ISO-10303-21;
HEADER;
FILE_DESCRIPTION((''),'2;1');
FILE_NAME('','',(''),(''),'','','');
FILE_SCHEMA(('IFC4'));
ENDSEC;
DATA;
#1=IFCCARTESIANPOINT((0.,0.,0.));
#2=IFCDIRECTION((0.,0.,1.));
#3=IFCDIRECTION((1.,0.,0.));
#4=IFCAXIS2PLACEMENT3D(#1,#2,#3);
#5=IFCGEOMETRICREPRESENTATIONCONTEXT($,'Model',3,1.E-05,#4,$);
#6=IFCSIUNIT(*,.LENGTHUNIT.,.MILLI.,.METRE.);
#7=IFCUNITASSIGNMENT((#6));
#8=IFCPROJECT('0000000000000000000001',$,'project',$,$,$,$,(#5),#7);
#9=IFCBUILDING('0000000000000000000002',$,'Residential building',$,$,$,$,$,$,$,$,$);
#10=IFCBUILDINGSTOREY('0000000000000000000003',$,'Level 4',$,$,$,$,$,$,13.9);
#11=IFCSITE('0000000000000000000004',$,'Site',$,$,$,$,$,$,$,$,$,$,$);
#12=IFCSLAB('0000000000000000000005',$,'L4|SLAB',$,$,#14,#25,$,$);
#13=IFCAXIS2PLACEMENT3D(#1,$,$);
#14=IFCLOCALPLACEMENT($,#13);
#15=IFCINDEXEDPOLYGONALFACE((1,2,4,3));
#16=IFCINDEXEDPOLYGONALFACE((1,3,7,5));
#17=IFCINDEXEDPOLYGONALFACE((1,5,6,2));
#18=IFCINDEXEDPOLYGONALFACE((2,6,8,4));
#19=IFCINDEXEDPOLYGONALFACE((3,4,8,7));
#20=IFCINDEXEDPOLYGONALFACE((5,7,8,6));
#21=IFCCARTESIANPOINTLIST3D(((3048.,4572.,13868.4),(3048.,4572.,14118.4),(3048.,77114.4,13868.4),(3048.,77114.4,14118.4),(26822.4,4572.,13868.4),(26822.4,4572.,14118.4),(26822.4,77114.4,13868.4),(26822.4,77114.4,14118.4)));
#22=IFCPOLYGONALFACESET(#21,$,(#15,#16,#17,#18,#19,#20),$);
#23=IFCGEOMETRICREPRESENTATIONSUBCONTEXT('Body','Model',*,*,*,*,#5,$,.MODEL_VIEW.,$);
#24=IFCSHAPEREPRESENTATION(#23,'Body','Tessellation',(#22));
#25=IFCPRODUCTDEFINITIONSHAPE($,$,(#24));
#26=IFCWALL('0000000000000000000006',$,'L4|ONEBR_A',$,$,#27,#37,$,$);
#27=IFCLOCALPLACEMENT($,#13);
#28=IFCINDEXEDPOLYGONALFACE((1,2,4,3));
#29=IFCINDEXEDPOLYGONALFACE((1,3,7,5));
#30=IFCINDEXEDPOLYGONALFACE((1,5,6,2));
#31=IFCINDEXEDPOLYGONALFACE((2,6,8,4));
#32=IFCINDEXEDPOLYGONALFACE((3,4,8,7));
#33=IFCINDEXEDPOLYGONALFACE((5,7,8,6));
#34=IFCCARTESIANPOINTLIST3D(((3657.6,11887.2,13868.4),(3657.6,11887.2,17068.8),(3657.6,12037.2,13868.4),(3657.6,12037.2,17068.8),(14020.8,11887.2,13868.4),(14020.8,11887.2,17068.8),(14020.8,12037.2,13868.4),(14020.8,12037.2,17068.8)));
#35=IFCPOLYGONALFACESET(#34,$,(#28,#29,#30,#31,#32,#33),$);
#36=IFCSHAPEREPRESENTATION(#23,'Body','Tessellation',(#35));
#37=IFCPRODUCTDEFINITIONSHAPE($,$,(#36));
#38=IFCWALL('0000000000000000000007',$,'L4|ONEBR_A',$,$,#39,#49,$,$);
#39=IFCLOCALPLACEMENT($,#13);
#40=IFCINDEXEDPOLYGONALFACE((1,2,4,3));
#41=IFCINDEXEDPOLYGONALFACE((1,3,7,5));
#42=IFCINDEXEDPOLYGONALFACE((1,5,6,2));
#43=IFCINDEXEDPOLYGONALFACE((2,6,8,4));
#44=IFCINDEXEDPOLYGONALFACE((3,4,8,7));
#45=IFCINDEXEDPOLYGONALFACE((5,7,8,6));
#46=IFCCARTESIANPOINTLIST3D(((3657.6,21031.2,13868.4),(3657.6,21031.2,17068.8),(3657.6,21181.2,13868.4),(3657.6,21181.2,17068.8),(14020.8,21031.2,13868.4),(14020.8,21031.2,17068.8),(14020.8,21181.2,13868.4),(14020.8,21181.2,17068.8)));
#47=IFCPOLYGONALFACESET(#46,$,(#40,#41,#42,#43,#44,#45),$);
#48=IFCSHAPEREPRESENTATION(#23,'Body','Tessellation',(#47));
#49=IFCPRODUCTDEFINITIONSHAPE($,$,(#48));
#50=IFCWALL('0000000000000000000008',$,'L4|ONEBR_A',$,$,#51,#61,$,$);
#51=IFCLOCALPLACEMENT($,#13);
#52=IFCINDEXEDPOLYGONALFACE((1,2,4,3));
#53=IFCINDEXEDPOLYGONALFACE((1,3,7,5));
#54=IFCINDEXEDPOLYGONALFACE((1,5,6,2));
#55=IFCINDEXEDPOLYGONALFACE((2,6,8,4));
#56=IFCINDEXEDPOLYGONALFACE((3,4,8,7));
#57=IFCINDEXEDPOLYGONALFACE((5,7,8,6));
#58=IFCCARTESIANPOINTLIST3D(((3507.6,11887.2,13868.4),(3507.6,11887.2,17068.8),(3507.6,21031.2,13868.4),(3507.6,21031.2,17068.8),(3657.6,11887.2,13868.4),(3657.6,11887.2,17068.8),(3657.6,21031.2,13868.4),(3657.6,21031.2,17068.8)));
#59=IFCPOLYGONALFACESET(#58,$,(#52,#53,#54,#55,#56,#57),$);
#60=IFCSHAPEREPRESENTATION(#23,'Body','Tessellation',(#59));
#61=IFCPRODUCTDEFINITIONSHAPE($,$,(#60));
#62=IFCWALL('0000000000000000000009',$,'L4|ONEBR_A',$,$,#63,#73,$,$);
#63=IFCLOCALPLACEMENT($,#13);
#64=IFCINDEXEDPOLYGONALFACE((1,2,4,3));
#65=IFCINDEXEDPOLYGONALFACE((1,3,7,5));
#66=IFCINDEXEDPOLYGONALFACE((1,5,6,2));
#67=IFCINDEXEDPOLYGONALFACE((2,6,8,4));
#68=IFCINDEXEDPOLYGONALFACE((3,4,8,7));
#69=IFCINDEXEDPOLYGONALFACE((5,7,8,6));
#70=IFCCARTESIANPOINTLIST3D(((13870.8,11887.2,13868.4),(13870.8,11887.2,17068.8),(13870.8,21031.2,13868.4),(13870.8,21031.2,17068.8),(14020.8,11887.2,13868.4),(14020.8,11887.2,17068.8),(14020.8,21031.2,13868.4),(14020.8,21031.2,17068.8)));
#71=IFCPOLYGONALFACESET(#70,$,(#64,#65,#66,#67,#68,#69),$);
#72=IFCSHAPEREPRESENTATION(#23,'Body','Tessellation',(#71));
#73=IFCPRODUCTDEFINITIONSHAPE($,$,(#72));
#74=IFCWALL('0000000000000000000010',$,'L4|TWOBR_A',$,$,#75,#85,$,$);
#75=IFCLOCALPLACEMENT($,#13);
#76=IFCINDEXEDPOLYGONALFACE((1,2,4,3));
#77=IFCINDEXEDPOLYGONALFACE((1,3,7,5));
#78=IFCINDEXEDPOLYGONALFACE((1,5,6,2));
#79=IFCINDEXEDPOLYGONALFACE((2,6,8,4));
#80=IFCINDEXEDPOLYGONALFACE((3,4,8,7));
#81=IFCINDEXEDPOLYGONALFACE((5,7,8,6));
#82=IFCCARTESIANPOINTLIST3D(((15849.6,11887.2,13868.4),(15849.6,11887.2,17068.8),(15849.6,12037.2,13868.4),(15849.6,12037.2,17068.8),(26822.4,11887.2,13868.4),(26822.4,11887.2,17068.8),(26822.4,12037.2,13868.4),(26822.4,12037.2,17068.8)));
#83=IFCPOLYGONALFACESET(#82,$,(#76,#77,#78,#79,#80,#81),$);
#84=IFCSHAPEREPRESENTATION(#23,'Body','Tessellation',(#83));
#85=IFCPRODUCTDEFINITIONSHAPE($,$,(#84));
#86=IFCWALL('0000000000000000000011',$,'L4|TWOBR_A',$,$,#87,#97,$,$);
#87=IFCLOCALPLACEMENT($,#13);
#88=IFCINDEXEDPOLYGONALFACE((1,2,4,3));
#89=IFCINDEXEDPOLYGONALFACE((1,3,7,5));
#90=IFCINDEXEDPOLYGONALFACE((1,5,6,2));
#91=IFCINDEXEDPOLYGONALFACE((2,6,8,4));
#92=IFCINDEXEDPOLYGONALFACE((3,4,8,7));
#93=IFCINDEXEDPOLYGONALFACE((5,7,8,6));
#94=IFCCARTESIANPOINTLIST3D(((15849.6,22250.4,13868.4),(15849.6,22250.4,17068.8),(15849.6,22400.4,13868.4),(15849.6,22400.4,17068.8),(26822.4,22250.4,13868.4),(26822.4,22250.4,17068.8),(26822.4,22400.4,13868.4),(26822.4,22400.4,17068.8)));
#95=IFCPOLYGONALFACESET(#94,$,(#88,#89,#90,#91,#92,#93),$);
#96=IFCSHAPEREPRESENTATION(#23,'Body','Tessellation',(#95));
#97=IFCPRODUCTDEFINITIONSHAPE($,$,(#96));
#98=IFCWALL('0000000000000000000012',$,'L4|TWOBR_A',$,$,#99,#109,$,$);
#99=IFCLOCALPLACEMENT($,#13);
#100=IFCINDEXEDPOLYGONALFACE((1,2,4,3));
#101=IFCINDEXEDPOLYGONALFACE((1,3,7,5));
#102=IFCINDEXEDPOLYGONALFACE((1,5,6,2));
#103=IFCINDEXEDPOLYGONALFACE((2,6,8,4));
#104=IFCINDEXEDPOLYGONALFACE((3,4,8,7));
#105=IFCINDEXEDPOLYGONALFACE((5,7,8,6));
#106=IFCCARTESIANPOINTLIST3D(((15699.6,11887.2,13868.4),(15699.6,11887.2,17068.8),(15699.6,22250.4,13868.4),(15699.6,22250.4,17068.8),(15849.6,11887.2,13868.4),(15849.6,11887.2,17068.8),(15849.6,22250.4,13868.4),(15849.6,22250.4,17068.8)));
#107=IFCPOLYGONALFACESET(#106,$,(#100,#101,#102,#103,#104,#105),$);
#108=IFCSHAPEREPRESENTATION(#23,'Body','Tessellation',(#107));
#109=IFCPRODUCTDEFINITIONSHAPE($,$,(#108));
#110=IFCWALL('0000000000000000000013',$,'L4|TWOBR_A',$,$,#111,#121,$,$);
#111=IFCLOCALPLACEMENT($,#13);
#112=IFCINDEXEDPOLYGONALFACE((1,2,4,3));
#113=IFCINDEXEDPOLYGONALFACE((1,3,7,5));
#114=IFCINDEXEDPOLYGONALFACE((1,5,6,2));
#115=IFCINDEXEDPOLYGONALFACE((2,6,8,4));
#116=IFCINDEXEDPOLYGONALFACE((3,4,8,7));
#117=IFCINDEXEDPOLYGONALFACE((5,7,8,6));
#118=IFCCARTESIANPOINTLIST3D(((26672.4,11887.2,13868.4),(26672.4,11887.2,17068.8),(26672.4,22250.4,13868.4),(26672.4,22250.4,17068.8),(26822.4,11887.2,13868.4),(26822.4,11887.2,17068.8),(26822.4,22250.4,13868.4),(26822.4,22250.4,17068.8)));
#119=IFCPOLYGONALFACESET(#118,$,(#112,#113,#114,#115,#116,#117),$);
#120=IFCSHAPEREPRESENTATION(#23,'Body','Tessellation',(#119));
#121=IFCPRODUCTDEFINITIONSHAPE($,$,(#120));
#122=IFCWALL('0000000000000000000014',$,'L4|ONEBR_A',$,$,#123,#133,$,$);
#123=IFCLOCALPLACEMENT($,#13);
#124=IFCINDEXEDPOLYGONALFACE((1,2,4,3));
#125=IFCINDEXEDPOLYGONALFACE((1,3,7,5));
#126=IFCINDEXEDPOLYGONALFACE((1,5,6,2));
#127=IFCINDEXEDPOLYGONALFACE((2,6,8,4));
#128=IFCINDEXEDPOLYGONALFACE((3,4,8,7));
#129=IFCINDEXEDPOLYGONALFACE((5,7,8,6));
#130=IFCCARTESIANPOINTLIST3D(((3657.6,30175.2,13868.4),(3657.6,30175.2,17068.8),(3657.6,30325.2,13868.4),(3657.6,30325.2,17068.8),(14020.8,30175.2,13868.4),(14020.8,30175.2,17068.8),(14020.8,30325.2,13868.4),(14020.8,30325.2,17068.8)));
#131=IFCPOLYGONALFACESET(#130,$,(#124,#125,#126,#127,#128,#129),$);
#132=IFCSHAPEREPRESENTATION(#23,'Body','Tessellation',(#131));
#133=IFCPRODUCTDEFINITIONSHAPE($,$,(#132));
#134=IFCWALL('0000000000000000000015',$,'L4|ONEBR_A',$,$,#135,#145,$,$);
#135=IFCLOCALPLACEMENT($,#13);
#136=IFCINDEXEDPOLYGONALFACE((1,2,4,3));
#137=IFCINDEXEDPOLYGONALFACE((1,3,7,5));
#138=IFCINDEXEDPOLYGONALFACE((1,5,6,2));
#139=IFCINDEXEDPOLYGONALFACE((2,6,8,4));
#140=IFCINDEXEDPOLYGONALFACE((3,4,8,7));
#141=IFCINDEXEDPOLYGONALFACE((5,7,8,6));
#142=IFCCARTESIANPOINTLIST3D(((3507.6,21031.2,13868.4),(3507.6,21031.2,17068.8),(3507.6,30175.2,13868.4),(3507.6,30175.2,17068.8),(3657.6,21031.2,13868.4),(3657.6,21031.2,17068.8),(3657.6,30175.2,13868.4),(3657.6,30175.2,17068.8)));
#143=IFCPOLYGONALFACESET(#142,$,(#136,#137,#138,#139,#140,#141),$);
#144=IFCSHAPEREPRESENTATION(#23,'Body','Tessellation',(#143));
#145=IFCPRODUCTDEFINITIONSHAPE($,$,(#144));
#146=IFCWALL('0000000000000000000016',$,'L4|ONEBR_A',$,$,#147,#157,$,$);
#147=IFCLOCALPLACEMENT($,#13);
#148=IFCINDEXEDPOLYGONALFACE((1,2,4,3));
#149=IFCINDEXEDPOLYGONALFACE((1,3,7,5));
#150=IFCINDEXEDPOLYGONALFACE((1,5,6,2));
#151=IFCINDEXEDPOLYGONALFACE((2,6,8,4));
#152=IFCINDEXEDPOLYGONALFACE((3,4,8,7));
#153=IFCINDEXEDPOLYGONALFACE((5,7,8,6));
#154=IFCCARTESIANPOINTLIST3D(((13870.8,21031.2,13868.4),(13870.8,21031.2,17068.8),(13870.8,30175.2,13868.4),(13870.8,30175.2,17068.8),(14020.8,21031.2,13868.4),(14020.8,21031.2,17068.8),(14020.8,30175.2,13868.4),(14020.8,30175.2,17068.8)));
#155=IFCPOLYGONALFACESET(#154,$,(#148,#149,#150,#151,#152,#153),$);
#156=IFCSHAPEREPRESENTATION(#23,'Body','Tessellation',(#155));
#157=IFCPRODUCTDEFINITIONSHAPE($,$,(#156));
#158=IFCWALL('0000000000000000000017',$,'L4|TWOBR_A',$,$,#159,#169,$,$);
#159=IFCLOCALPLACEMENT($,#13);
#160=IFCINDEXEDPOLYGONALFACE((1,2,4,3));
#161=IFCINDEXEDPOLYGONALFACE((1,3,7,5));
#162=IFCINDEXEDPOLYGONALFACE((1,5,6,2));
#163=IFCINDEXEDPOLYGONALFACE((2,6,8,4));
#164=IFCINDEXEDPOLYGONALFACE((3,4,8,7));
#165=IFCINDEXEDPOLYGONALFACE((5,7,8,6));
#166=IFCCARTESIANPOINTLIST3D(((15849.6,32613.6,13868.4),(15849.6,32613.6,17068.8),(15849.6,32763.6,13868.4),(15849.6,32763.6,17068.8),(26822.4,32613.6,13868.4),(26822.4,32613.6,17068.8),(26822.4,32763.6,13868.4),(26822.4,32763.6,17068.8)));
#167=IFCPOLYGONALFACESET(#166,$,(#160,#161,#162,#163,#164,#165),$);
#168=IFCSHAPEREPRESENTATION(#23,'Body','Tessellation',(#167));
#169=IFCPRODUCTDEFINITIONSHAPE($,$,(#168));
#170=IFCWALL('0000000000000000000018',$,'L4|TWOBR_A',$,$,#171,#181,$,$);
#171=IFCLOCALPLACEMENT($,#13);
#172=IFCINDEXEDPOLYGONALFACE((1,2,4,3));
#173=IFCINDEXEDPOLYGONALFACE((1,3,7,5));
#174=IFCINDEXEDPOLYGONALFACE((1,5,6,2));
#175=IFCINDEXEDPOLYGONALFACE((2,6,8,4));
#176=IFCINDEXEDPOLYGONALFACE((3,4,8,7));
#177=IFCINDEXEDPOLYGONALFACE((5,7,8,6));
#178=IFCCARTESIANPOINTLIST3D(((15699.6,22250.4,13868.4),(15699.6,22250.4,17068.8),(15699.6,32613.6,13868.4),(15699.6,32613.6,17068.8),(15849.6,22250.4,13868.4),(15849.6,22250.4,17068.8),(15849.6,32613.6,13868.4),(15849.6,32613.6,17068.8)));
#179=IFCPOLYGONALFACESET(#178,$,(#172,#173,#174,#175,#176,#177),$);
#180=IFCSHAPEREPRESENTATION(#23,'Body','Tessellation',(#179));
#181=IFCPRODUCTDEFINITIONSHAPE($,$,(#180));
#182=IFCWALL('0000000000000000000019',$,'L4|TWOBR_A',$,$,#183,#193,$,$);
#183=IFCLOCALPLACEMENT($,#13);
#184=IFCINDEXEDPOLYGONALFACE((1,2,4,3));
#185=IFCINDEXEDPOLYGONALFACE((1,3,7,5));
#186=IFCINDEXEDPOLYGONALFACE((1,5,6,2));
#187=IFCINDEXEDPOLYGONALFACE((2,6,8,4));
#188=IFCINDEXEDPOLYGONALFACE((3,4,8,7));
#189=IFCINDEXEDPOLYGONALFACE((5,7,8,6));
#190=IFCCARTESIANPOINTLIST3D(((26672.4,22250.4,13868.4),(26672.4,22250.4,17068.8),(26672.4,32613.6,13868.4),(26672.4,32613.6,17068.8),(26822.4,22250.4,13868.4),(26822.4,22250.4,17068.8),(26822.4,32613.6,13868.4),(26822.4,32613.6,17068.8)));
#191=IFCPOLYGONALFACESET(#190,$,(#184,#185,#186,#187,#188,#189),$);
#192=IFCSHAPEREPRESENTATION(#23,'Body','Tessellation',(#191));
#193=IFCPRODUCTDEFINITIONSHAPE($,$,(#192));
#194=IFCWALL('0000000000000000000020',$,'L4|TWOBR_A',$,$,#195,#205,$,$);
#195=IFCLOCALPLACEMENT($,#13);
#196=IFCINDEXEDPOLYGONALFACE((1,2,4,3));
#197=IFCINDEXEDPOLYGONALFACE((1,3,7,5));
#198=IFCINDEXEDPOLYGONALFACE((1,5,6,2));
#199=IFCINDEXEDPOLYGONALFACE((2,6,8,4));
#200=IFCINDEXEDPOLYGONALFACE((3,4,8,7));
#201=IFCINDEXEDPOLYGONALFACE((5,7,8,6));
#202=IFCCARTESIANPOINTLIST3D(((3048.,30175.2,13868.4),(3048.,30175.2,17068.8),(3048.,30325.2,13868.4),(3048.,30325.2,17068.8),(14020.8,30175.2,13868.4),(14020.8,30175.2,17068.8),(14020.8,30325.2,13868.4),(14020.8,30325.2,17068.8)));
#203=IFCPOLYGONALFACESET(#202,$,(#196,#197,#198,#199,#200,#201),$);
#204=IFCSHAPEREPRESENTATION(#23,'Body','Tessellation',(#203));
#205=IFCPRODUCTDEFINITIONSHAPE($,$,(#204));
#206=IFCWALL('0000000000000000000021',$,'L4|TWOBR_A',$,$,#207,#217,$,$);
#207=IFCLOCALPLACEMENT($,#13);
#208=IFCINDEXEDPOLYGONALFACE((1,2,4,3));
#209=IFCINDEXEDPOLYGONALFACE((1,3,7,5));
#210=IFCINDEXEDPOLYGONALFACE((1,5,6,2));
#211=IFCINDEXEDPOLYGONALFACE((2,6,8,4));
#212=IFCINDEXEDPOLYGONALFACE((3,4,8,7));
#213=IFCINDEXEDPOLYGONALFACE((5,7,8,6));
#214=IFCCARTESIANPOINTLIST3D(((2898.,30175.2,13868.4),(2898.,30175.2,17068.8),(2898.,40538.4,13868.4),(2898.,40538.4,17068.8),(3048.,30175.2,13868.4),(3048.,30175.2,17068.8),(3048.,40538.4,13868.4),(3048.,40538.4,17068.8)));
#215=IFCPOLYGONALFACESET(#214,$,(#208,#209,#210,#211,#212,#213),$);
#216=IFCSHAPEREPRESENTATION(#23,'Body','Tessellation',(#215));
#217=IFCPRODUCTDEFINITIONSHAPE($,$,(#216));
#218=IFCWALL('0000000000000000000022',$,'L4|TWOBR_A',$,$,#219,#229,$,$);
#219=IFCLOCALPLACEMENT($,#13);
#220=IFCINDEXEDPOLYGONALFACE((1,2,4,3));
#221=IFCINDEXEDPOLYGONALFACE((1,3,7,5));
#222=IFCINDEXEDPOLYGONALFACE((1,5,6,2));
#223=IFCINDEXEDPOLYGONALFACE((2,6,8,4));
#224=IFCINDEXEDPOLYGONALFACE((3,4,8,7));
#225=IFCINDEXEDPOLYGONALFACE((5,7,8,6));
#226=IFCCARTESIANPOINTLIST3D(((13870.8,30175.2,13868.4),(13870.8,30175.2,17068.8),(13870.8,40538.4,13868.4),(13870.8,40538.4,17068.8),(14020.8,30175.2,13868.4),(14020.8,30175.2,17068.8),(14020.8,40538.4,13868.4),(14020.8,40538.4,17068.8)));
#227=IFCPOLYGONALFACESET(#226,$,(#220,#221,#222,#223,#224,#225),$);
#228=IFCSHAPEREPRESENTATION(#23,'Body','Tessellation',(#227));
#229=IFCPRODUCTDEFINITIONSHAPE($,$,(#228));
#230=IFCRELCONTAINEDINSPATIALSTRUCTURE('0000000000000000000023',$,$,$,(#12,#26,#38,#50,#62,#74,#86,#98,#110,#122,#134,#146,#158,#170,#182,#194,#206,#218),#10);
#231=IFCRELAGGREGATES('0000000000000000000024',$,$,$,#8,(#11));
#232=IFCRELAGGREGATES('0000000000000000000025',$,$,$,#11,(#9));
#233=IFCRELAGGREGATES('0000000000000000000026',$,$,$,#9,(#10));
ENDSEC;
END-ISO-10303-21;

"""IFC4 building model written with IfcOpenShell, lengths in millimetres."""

from ifc_helpers import new_model, si_unit, frame, origin_with_axes, place, context, subcontext, project, spatial, indexed_curve, outline, extrude, element, save


model = new_model("IFC4")

# Units and contexts
model_context = context("Model", 3, precision=1e-05, world=origin_with_axes())
body_context = subcontext(model_context, "Body", "Model", "MODEL_VIEW")
ifc_project = project(units=[si_unit("LENGTHUNIT", "METRE", prefix="MILLI")], contexts=[model_context])

# Site, building, storey
site = spatial("IfcSite", under=ifc_project, Name="Site")
building = spatial("IfcBuilding", under=site, Name="Residential building")
storey = spatial("IfcBuildingStorey", under=building, Name="Level 4", Elevation=13.9)

# Slab
slab_placement = place(None, frame((3048.0, 4572.0, 13868.4), z_axis=(0.0, 0.0, 1.0), x_axis=(1.0, 0.0, 0.0)))
element("IfcSlab", 1, at=slab_placement, inside=storey, Name="L4|SLAB", context=body_context, shape_type="SweptSolid", body=[
    extrude(outline(indexed_curve([(0.0, 0.0), (23774.4, 0.0), (23774.4, 72542.4), (0.0, 72542.4), (0.0, 0.0)])), None, (0.0, 0.0, 1.0), 250.0),
])

# Walls
for number, where, z_axis, x_axis, name in (
    (2, (3657.6, 11887.2, 13868.4), (0.0, 0.0, 1.0), (1.0, 0.0, 0.0), "L4|ONEBR_A"),
    (3, (3657.6, 21031.2, 13868.4), (0.0, 0.0, 1.0), (1.0, 0.0, 0.0), "L4|ONEBR_A"),
):
    element("IfcWall", number, at=place(None, frame(where, z_axis=z_axis, x_axis=x_axis)), inside=storey, Name=name, context=body_context, shape_type="SweptSolid", body=[
        extrude(outline(indexed_curve([(0.0, 0.0), (0.0, 150.0), (10363.2, 150.0), (10363.2, 0.0), (0.0, 0.0)], self_intersect=False)), origin_with_axes(), (0.0, 0.0, 1.0), 3200.4),
    ])
for number, where, z_axis, x_axis, name in (
    (4, (3657.6, 11887.2, 13868.4), (0.0, 0.0, 1.0), (0.0, 1.0, 0.0), "L4|ONEBR_A"),
    (5, (14020.8, 11887.2, 13868.4), (0.0, 0.0, 1.0), (0.0, 1.0, 0.0), "L4|ONEBR_A"),
):
    element("IfcWall", number, at=place(None, frame(where, z_axis=z_axis, x_axis=x_axis)), inside=storey, Name=name, context=body_context, shape_type="SweptSolid", body=[
        extrude(outline(indexed_curve([(0.0, 0.0), (0.0, 150.0), (9144.0, 150.0), (9144.0, 0.0), (0.0, 0.0)], self_intersect=False)), origin_with_axes(), (0.0, 0.0, 1.0), 3200.4),
    ])
for number, where, z_axis, x_axis, name in (
    (6, (15849.6, 11887.2, 13868.4), (0.0, 0.0, 1.0), (1.0, 0.0, 0.0), "L4|TWOBR_A"),
    (7, (15849.6, 22250.4, 13868.4), (0.0, 0.0, 1.0), (1.0, 0.0, 0.0), "L4|TWOBR_A"),
):
    element("IfcWall", number, at=place(None, frame(where, z_axis=z_axis, x_axis=x_axis)), inside=storey, Name=name, context=body_context, shape_type="SweptSolid", body=[
        extrude(outline(indexed_curve([(0.0, 0.0), (0.0, 150.0), (10972.8, 150.0), (10972.8, 0.0), (0.0, 0.0)], self_intersect=False)), origin_with_axes(), (0.0, 0.0, 1.0), 3200.4),
    ])
for number, where, z_axis, x_axis, name in (
    (8, (15849.6, 11887.2, 13868.4), (0.0, 0.0, 1.0), (0.0, 1.0, 0.0), "L4|TWOBR_A"),
    (9, (26822.4, 11887.2, 13868.4), (0.0, 0.0, 1.0), (0.0, 1.0, 0.0), "L4|TWOBR_A"),
    (10, (3657.6, 30175.2, 13868.4), (0.0, 0.0, 1.0), (1.0, 0.0, 0.0), "L4|ONEBR_A"),
):
    element("IfcWall", number, at=place(None, frame(where, z_axis=z_axis, x_axis=x_axis)), inside=storey, Name=name, context=body_context, shape_type="SweptSolid", body=[
        extrude(outline(indexed_curve([(0.0, 0.0), (0.0, 150.0), (10363.2, 150.0), (10363.2, 0.0), (0.0, 0.0)], self_intersect=False)), origin_with_axes(), (0.0, 0.0, 1.0), 3200.4),
    ])
for number, where, z_axis, x_axis, name in (
    (11, (3657.6, 21031.2, 13868.4), (0.0, 0.0, 1.0), (0.0, 1.0, 0.0), "L4|ONEBR_A"),
    (12, (14020.8, 21031.2, 13868.4), (0.0, 0.0, 1.0), (0.0, 1.0, 0.0), "L4|ONEBR_A"),
):
    element("IfcWall", number, at=place(None, frame(where, z_axis=z_axis, x_axis=x_axis)), inside=storey, Name=name, context=body_context, shape_type="SweptSolid", body=[
        extrude(outline(indexed_curve([(0.0, 0.0), (0.0, 150.0), (9144.0, 150.0), (9144.0, 0.0), (0.0, 0.0)], self_intersect=False)), origin_with_axes(), (0.0, 0.0, 1.0), 3200.4),
    ])
for number, where, z_axis, x_axis, name in (
    (13, (15849.6, 32613.6, 13868.4), (0.0, 0.0, 1.0), (1.0, 0.0, 0.0), "L4|TWOBR_A"),
):
    element("IfcWall", number, at=place(None, frame(where, z_axis=z_axis, x_axis=x_axis)), inside=storey, Name=name, context=body_context, shape_type="SweptSolid", body=[
        extrude(outline(indexed_curve([(0.0, 0.0), (0.0, 150.0), (10972.8, 150.0), (10972.8, 0.0), (0.0, 0.0)], self_intersect=False)), origin_with_axes(), (0.0, 0.0, 1.0), 3200.4),
    ])
for number, where, z_axis, x_axis, name in (
    (14, (15849.6, 22250.4, 13868.4), (0.0, 0.0, 1.0), (0.0, 1.0, 0.0), "L4|TWOBR_A"),
    (15, (26822.4, 22250.4, 13868.4), (0.0, 0.0, 1.0), (0.0, 1.0, 0.0), "L4|TWOBR_A"),
):
    element("IfcWall", number, at=place(None, frame(where, z_axis=z_axis, x_axis=x_axis)), inside=storey, Name=name, context=body_context, shape_type="SweptSolid", body=[
        extrude(outline(indexed_curve([(0.0, 0.0), (0.0, 150.0), (10363.2, 150.0), (10363.2, 0.0), (0.0, 0.0)], self_intersect=False)), origin_with_axes(), (0.0, 0.0, 1.0), 3200.4),
    ])
wall_1_placement = place(None, frame((3048.0, 30175.2, 13868.4), z_axis=(0.0, 0.0, 1.0), x_axis=(1.0, 0.0, 0.0)))
element("IfcWall", 16, at=wall_1_placement, inside=storey, Name="L4|TWOBR_A", context=body_context, shape_type="SweptSolid", body=[
    extrude(outline(indexed_curve([(0.0, 0.0), (0.0, 150.0), (10972.8, 150.0), (10972.8, 0.0), (0.0, 0.0)], self_intersect=False)), origin_with_axes(), (0.0, 0.0, 1.0), 3200.4),
])
for number, where, z_axis, x_axis, name in (
    (17, (3048.0, 30175.2, 13868.4), (0.0, 0.0, 1.0), (0.0, 1.0, 0.0), "L4|TWOBR_A"),
    (18, (14020.8, 30175.2, 13868.4), (0.0, 0.0, 1.0), (0.0, 1.0, 0.0), "L4|TWOBR_A"),
):
    element("IfcWall", number, at=place(None, frame(where, z_axis=z_axis, x_axis=x_axis)), inside=storey, Name=name, context=body_context, shape_type="SweptSolid", body=[
        extrude(outline(indexed_curve([(0.0, 0.0), (0.0, 150.0), (10363.2, 150.0), (10363.2, 0.0), (0.0, 0.0)], self_intersect=False)), origin_with_axes(), (0.0, 0.0, 1.0), 3200.4),
    ])

save(model, "model.ifc")
